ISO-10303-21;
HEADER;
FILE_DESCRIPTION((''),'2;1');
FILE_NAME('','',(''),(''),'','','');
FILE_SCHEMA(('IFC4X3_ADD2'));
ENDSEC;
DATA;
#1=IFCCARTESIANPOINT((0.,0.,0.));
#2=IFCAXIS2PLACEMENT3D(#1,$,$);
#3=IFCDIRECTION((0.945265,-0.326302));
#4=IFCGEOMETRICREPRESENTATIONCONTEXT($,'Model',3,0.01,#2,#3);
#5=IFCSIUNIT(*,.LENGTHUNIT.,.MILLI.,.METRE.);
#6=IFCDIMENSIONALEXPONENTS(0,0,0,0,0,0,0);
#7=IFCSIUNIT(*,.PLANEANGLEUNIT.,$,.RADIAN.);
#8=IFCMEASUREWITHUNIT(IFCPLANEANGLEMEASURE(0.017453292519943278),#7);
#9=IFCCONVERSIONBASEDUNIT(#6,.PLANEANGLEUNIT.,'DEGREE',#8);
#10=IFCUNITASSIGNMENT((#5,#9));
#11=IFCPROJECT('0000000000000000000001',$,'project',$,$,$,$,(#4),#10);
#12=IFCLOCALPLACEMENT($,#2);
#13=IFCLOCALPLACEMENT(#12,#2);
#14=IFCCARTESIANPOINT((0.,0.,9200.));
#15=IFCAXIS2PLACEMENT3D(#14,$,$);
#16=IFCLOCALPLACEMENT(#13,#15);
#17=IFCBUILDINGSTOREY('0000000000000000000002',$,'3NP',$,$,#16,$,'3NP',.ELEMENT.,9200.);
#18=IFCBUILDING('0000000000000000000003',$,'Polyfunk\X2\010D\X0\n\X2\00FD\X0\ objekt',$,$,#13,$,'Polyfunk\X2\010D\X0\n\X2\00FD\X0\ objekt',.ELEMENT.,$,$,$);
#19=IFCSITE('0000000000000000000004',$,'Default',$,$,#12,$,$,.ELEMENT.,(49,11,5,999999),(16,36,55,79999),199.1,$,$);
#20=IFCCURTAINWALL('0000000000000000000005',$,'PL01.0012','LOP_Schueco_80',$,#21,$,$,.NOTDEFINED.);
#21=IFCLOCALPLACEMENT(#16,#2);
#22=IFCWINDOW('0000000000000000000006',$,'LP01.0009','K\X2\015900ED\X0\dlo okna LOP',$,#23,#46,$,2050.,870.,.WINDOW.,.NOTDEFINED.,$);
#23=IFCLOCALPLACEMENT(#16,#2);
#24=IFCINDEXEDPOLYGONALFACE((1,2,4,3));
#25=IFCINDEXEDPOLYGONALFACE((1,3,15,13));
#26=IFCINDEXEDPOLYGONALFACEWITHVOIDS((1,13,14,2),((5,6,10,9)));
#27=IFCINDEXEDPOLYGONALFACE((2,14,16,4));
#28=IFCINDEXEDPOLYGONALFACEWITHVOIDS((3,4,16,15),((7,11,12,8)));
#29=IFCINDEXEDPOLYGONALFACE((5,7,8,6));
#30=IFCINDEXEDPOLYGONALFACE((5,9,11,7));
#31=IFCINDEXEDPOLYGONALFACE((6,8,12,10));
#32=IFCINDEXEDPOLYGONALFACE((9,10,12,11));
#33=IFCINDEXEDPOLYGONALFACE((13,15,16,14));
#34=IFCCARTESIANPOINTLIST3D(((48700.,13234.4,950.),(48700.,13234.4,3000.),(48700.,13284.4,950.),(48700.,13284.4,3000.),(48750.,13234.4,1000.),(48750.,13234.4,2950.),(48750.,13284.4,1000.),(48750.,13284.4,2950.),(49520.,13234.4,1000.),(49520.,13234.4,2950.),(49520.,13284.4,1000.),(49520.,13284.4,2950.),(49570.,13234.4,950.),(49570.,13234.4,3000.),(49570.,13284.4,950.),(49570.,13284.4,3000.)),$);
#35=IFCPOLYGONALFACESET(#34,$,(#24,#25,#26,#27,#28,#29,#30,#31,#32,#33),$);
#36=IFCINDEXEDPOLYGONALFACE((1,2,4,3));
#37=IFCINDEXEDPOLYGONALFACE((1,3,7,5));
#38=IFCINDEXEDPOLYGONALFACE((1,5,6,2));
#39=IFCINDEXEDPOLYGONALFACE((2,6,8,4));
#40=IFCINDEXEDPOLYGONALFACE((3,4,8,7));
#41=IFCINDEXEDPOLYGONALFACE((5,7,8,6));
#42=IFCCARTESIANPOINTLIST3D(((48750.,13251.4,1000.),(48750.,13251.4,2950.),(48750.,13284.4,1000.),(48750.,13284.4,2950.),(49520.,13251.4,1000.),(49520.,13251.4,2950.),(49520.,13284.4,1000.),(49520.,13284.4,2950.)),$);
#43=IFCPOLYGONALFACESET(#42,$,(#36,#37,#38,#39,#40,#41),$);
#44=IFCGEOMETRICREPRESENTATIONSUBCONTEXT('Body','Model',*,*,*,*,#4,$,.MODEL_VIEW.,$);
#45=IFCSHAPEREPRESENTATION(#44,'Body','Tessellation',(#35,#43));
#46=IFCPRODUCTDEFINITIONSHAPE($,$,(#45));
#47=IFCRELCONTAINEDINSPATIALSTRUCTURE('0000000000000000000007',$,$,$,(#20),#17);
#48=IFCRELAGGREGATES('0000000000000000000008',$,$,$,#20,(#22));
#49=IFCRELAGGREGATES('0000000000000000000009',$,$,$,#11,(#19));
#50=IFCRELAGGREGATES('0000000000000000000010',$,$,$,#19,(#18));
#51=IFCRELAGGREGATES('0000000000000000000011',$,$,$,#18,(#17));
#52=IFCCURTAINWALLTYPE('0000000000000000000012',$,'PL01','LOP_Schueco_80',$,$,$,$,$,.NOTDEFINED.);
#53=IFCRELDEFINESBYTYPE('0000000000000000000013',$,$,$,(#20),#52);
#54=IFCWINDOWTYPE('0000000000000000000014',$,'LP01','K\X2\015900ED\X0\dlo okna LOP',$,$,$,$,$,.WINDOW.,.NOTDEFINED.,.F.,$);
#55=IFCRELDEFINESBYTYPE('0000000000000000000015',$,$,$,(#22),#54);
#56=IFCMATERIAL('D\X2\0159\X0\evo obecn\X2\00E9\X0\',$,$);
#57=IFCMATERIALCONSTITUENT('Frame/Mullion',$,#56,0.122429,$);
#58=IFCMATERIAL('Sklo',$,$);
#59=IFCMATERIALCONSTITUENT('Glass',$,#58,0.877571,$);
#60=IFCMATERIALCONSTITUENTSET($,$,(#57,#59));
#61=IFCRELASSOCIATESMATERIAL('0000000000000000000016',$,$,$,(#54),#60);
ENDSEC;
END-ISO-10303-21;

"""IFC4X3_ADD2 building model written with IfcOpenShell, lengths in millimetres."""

from ifc_helpers import new_model, entity, si_unit, converted_unit, direction, frame, origin, origin_2d_with_axis, place, context, subcontext, project, spatial, polyline, rectangle, outline, extrude, source, transform, mapped, material, constituent, constituent_set, type_object, type_shapes, element, aggregate, save


model = new_model("IFC4X3_ADD2")

# Units and contexts
model_context = context("Model", 3, precision=0.01, world=origin(), true_north=direction((0.945265, -0.326302)))
body_context = subcontext(model_context, "Body", "Model", "MODEL_VIEW")
ifc_project = project(units=[si_unit("LENGTHUNIT", "METRE", prefix="MILLI"), converted_unit("PLANEANGLEUNIT", "DEGREE", entity("IfcPlaneAngleMeasure", 0.017453292519943278), si_unit("PLANEANGLEUNIT", "RADIAN"), dimensions=[0, 0, 0, 0, 0, 0, 0])], contexts=[model_context])

# Site, building, storey
site_placement = place(None, origin())
site = spatial("IfcSite", under=ifc_project, at=site_placement, Name="Default", CompositionType="ELEMENT", RefLatitude=(49, 11, 5, 999999), RefLongitude=(16, 36, 55, 79999), RefElevation=199.1)
building_placement = place(site_placement, origin())
building = spatial("IfcBuilding", under=site, at=building_placement, Name="Polyfunkčný objekt", LongName="Polyfunkčný objekt", CompositionType="ELEMENT")
storey_placement = place(building_placement, frame((0.0, 0.0, 9200.0)))
storey = spatial("IfcBuildingStorey", under=building, at=storey_placement, Name="3NP", LongName="3NP", CompositionType="ELEMENT", Elevation=9200.0)

# Curtain wall
curtain_wall_type = type_object("IfcCurtainWallType", Name="PL01", Description="LOP_Schueco_80", PredefinedType="NOTDEFINED")
curtain_wall_placement = place(storey_placement, frame((0.0, 0.0, -9200.0)))
curtain_wall = element("IfcCurtainWall", 1, at=curtain_wall_placement, inside=storey, type_object=curtain_wall_type, Name="PL01.0012", Description="LOP_Schueco_80", PredefinedType="NOTDEFINED")
ifc_material_1 = material(Name="Sklo")

# Window
ifc_material_2 = material(Name="Dřevo obecné")
ifc_constituent_1 = constituent(ifc_material_2, Name="Frame/Mullion", fraction=0.122429)
ifc_constituent_2 = constituent(ifc_material_1, Name="Glass", fraction=0.877571)
ifc_constituent_set = constituent_set(constituents=[ifc_constituent_1, ifc_constituent_2])
window_type = type_object("IfcWindowType", Name="LP01", Description="Křídlo okna LOP", ParameterTakesPrecedence=False, PartitioningType="NOTDEFINED", PredefinedType="WINDOW", material=ifc_constituent_set)
shared_shape_1 = source(origin(), body_context, "Body", "SweptSolid", [
    extrude(outline(polyline([(-1025.0, -435.0), (1025.0, -435.0), (1025.0, 435.0), (-1025.0, 435.0), (-1025.0, -435.0)]), holes=[polyline([(-975.0, -385.0), (-975.0, 385.0), (975.0, 385.0), (975.0, -385.0), (-975.0, -385.0)])]), frame((0.0, 0.0, 1025.0), z_axis=(0.0, 1.0, 0.0), x_axis=(0.0, 0.0, -1.0)), (0.0, 0.0, 1.0), 50.0),
    extrude(rectangle(XDim=33.0, YDim=770.0, at=origin_2d_with_axis()), frame((0.0, 33.5, 50.0), z_axis=(0.0, 0.0, 1.0), x_axis=(0.0, -1.0, 0.0)), (0.0, 0.0, 1.0), 1950.0),
])
type_shapes(window_type, [shared_shape_1])
window_placement = place(curtain_wall_placement, frame((49135.0, 13234.4, 10150.0)))
window = element("IfcWindow", 2, at=window_placement, type_object=window_type, Name="LP01.0009", Description="Křídlo okna LOP", OverallHeight=2050.0, OverallWidth=870.0, PartitioningType="NOTDEFINED", PredefinedType="WINDOW", context=body_context, shape_type="MappedRepresentation", body=[
    mapped(shared_shape_1, transform((0.0, 0.0, 0.0), scale=1.0)),
])
aggregate(curtain_wall, [window])

save(model, "model.ifc")
